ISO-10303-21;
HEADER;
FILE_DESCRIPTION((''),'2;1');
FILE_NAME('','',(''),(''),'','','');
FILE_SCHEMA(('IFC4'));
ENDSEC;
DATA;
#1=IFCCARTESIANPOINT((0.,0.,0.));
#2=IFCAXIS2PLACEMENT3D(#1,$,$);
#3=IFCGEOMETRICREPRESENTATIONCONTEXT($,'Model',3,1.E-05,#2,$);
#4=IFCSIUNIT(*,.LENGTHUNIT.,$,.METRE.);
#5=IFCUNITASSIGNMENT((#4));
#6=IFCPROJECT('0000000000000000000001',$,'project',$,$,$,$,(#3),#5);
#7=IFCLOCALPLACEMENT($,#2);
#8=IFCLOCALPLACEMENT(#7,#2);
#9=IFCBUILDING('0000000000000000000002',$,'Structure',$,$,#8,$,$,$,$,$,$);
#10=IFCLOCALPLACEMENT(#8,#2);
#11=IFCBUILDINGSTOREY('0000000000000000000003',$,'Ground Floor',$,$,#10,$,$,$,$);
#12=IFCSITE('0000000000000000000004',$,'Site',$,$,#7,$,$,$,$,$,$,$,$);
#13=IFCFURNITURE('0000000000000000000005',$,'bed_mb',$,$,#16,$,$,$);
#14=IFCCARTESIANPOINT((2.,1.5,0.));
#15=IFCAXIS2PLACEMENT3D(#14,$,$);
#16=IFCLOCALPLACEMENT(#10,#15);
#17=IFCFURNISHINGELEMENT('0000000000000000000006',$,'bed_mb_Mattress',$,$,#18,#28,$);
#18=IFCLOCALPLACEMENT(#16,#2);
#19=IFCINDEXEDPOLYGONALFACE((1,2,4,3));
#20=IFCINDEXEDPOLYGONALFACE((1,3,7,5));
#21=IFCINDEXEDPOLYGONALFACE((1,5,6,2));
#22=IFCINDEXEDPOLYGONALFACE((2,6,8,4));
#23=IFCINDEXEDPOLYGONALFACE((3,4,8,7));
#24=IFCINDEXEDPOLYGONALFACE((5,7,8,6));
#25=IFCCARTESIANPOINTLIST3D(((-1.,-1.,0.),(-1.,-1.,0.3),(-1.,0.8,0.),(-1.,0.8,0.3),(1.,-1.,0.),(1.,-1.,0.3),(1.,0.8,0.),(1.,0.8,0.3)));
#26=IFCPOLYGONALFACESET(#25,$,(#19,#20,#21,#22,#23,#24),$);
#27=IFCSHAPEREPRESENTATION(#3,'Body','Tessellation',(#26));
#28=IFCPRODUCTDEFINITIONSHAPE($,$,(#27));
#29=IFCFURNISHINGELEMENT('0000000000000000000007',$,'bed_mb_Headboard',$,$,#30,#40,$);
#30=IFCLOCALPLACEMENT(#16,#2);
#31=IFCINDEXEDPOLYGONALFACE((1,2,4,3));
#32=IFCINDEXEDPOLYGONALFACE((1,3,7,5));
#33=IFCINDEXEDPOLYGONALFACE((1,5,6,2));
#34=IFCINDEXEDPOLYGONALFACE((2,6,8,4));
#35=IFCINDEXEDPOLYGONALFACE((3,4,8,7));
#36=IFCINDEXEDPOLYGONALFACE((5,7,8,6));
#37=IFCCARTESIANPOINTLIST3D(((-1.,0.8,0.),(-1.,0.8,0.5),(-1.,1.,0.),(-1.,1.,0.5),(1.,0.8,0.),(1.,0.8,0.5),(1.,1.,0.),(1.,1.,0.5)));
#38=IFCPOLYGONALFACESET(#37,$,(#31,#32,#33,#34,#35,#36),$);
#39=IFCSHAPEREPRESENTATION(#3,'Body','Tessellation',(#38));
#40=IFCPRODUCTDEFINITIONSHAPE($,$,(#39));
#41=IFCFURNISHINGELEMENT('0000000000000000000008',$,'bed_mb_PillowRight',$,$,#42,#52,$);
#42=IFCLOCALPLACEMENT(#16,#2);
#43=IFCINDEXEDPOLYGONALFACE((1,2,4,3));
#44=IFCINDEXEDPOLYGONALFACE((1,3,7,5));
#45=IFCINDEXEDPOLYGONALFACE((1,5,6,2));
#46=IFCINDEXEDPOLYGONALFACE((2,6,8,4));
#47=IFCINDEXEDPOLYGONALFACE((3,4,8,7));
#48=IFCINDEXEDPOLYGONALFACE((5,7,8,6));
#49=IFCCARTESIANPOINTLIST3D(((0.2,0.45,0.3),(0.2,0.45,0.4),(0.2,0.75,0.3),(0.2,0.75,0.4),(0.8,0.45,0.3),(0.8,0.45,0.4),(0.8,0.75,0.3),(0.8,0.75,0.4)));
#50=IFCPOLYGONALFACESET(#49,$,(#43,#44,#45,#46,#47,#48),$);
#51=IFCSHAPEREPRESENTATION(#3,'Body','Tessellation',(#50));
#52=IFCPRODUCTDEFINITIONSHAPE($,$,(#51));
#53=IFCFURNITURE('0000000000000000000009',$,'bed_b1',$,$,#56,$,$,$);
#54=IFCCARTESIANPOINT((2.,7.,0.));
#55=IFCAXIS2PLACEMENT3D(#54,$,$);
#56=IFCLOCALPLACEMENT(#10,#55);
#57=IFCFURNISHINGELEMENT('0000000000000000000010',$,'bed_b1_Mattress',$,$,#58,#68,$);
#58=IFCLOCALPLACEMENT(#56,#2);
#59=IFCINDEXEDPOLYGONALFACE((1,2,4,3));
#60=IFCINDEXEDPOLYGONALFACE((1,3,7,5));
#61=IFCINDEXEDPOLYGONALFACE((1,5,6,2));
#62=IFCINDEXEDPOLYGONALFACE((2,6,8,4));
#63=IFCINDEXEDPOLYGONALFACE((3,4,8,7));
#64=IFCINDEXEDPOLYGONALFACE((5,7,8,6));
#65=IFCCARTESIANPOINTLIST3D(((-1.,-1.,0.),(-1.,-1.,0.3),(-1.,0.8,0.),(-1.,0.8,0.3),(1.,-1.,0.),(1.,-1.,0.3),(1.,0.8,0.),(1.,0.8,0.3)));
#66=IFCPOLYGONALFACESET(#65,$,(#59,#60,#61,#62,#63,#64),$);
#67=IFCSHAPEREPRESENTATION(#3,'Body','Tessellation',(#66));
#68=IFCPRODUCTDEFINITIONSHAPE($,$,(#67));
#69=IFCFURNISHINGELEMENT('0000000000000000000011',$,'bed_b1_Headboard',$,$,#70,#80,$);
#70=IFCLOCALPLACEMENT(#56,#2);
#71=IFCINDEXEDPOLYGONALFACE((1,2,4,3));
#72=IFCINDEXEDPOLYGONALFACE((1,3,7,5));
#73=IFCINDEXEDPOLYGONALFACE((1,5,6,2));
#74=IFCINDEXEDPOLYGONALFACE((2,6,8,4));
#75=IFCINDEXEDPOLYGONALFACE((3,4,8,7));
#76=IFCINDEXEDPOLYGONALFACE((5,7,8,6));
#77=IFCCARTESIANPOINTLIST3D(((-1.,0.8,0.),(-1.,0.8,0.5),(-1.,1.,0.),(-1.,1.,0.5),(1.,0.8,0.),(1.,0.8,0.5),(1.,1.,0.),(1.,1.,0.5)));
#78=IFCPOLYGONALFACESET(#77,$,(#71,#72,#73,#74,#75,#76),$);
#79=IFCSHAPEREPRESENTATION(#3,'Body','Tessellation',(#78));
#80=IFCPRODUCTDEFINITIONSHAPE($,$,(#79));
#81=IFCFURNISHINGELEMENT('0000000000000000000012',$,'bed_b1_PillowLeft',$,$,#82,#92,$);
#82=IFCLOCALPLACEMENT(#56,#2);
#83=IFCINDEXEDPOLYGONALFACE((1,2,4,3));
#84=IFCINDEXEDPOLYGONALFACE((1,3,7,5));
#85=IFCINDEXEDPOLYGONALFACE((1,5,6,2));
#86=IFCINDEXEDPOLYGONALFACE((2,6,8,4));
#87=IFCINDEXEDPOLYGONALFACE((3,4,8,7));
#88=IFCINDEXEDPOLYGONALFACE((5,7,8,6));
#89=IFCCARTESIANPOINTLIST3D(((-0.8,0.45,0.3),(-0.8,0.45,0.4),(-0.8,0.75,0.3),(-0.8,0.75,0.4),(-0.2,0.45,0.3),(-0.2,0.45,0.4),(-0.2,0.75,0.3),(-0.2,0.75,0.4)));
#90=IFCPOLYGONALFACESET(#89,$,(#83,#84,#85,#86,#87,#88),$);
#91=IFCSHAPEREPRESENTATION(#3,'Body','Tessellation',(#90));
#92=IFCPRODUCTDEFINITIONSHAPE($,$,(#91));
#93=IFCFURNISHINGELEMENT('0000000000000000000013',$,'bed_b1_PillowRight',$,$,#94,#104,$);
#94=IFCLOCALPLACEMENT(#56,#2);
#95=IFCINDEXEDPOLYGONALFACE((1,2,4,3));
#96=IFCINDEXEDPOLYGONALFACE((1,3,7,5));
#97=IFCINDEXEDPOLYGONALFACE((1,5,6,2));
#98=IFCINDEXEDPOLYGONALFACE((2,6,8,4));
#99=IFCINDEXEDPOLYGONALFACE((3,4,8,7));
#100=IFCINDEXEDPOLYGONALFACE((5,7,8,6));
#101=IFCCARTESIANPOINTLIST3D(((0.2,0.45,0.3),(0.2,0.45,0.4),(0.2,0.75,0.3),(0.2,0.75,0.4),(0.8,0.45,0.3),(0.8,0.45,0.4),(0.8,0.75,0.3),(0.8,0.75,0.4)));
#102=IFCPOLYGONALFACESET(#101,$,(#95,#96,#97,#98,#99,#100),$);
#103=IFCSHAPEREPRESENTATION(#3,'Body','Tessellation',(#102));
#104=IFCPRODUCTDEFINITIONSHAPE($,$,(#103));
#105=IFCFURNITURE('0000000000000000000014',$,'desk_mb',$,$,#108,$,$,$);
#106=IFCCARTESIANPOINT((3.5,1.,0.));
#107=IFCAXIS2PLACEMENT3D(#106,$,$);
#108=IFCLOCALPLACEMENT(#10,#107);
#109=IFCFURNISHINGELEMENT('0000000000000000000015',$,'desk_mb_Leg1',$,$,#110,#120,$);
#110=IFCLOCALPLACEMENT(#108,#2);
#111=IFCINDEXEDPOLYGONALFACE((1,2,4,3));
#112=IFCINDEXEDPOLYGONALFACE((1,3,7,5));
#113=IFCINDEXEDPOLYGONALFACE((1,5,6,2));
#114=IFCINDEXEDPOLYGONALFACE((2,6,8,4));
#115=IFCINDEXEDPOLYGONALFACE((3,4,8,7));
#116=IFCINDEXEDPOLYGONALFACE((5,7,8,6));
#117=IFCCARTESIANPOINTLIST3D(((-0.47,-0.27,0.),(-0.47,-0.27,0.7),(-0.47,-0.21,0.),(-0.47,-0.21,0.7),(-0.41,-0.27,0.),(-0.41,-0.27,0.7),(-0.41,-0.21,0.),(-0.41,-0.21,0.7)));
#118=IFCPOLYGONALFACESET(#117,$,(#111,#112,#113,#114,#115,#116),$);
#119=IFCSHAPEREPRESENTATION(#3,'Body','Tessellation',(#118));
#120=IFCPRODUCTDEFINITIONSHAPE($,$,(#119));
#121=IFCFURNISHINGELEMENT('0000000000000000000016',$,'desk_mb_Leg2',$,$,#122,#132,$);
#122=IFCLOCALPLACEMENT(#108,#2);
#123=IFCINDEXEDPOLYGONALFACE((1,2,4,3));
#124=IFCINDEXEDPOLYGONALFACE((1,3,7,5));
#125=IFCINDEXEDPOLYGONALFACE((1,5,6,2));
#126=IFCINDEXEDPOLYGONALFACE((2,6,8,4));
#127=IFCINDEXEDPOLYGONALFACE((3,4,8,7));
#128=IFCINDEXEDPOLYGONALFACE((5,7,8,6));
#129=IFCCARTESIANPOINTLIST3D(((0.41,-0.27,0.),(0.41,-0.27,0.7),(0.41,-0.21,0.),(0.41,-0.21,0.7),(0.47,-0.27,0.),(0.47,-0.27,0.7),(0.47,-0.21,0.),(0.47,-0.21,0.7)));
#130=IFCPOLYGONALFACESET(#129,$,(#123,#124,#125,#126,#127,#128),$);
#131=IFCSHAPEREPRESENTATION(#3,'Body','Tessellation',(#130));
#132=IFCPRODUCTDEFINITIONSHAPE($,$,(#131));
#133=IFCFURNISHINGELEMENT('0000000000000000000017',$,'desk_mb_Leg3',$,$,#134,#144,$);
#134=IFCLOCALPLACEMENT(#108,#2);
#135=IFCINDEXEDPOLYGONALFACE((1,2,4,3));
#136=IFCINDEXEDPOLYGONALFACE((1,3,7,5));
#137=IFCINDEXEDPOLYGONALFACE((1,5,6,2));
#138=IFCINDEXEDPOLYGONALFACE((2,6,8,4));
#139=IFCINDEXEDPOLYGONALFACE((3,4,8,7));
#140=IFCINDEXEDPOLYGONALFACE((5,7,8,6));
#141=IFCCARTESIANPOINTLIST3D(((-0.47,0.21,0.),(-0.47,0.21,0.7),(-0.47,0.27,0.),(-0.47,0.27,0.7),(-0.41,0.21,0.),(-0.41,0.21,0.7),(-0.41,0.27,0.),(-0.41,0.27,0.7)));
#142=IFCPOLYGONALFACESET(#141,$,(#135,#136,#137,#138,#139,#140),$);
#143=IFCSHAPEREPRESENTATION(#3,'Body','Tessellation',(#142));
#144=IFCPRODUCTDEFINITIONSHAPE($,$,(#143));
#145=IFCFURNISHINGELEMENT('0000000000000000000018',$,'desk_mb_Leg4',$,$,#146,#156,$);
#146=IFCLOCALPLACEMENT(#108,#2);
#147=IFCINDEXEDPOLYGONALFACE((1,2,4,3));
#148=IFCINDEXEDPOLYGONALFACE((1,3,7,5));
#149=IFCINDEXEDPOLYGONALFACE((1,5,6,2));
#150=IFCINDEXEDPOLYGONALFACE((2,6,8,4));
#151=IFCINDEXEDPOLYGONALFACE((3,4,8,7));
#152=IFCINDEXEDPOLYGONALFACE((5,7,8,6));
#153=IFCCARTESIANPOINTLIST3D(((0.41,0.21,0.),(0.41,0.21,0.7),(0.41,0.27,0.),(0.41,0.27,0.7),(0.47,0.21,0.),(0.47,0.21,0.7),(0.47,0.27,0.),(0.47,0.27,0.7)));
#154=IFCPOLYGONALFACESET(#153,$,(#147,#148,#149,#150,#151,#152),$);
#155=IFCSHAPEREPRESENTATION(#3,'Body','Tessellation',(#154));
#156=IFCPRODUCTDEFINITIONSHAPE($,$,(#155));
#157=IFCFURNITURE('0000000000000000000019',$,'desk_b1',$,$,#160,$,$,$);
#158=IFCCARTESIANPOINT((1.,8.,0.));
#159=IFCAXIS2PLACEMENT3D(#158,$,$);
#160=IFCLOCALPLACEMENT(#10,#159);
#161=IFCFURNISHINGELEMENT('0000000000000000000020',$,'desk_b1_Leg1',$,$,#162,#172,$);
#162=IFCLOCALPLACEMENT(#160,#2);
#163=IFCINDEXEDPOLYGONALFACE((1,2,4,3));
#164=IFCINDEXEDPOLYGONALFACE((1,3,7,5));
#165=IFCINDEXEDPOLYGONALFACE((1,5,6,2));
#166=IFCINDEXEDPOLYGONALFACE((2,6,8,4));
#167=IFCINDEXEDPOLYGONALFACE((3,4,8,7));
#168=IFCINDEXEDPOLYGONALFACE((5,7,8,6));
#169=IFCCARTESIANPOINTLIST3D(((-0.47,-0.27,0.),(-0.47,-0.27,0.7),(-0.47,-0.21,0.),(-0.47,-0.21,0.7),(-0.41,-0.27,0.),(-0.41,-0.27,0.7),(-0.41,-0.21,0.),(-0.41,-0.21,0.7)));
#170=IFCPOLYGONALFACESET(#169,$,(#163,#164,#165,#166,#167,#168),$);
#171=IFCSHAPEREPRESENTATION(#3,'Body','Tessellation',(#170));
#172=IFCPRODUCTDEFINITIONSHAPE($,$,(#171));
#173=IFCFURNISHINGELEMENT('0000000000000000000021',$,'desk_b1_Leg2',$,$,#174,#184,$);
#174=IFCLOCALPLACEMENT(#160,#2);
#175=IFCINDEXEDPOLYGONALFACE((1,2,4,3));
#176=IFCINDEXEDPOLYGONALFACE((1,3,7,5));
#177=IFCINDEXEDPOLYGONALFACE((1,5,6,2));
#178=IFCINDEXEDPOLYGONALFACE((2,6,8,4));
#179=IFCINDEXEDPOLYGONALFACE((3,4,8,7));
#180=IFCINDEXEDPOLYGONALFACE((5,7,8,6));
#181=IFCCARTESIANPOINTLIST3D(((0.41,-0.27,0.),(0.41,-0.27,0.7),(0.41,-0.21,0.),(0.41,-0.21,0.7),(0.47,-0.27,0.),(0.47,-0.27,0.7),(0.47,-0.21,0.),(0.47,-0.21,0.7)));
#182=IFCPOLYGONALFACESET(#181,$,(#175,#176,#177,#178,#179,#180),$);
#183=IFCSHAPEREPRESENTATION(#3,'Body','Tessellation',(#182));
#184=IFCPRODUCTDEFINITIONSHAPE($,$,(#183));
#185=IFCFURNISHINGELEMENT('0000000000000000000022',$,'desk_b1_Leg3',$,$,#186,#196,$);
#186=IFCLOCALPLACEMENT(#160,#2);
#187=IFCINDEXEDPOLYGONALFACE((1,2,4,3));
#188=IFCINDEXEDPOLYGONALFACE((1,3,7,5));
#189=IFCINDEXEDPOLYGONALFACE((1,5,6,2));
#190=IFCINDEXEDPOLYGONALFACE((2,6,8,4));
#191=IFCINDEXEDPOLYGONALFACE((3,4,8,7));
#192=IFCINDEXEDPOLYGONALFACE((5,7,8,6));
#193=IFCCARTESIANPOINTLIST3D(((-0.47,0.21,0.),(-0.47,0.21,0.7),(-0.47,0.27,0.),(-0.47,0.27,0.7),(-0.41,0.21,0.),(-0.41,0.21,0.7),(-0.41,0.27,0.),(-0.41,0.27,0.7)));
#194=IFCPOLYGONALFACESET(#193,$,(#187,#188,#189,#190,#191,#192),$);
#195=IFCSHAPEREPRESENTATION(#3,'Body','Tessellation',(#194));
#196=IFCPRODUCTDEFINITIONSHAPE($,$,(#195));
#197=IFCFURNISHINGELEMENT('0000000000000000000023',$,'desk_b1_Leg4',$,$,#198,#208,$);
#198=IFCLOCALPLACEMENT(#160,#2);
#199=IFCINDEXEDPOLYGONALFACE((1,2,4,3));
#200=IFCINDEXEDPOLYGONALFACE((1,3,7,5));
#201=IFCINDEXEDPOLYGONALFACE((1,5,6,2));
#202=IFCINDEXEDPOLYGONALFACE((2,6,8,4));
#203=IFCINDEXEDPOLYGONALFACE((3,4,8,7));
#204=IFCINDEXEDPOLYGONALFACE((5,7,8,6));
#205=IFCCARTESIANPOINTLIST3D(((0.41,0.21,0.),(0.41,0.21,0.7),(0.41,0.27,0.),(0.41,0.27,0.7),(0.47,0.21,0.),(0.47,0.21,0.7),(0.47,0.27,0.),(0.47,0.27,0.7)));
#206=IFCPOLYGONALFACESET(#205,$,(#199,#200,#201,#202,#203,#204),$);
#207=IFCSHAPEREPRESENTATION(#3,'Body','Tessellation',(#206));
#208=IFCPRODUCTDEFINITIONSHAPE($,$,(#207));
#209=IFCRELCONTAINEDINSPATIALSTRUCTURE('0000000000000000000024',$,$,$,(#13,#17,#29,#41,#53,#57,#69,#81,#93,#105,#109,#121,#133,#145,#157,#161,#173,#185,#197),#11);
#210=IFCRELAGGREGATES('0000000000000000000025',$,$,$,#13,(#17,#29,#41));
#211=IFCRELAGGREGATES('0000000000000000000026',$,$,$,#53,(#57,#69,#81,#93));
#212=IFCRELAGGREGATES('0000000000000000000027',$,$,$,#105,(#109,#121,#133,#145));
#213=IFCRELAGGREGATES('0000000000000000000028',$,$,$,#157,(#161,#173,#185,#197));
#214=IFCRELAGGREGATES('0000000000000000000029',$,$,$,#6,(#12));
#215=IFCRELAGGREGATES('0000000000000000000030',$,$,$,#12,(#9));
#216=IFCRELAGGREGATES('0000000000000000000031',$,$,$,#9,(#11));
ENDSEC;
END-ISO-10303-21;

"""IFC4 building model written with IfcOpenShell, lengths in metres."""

from ifc_helpers import new_model, si_unit, frame, origin, origin_2d, place, context, project, spatial, rectangle, extrude, element, aggregate, save


model = new_model("IFC4")

# Units and contexts
model_context = context("Model", 3, precision=1e-05, world=origin())
ifc_project = project(units=[si_unit("LENGTHUNIT", "METRE")], contexts=[model_context])

# Site, building, storey
site_placement = place(None, origin())
site = spatial("IfcSite", under=ifc_project, at=site_placement, Name="Site")
building_placement = place(site_placement, origin())
building = spatial("IfcBuilding", under=site, at=building_placement, Name="Structure")
storey_placement = place(building_placement, origin())
storey = spatial("IfcBuildingStorey", under=building, at=storey_placement, Name="Ground Floor")

# Furniture, furnishing elements
furniture_1_placement = place(storey_placement, frame((2.0, 1.5, 0.0)))
furniture_1 = element("IfcFurniture", 1, at=furniture_1_placement, inside=storey, Name="bed_mb")
furnishing_1_placement = place(furniture_1_placement, origin())
furnishing_1 = element("IfcFurnishingElement", 2, at=furnishing_1_placement, inside=storey, Name="bed_mb_Mattress", context=model_context, shape_type="SweptSolid", body=[
    extrude(rectangle(XDim=2.0, YDim=1.8, at=origin_2d()), frame((0.0, -0.1, 0.0)), (0.0, 0.0, 1.0), 0.3),
])
furnishing_2_placement = place(furniture_1_placement, origin())
furnishing_2 = element("IfcFurnishingElement", 3, at=furnishing_2_placement, inside=storey, Name="bed_mb_Headboard", context=model_context, shape_type="SweptSolid", body=[
    extrude(rectangle(XDim=2.0, YDim=0.2, at=origin_2d()), frame((0.0, 0.9, 0.0)), (0.0, 0.0, 1.0), 0.5),
])
furnishing_3_placement = place(furniture_1_placement, origin())
furnishing_3 = element("IfcFurnishingElement", 4, at=furnishing_3_placement, inside=storey, Name="bed_mb_PillowRight", context=model_context, shape_type="SweptSolid", body=[
    extrude(rectangle(XDim=0.6, YDim=0.3, at=origin_2d()), frame((0.5, 0.6, 0.3)), (0.0, 0.0, 1.0), 0.1),
])
aggregate(furniture_1, [furnishing_1, furnishing_2, furnishing_3])
furniture_2_placement = place(storey_placement, frame((2.0, 7.0, 0.0)))
furniture_2 = element("IfcFurniture", 5, at=furniture_2_placement, inside=storey, Name="bed_b1")
furnishing_4_placement = place(furniture_2_placement, origin())
furnishing_4 = element("IfcFurnishingElement", 6, at=furnishing_4_placement, inside=storey, Name="bed_b1_Mattress", context=model_context, shape_type="SweptSolid", body=[
    extrude(rectangle(XDim=2.0, YDim=1.8, at=origin_2d()), frame((0.0, -0.1, 0.0)), (0.0, 0.0, 1.0), 0.3),
])
furnishing_5_placement = place(furniture_2_placement, origin())
furnishing_5 = element("IfcFurnishingElement", 7, at=furnishing_5_placement, inside=storey, Name="bed_b1_Headboard", context=model_context, shape_type="SweptSolid", body=[
    extrude(rectangle(XDim=2.0, YDim=0.2, at=origin_2d()), frame((0.0, 0.9, 0.0)), (0.0, 0.0, 1.0), 0.5),
])
furnishing_6_placement = place(furniture_2_placement, origin())
furnishing_6 = element("IfcFurnishingElement", 8, at=furnishing_6_placement, inside=storey, Name="bed_b1_PillowLeft", context=model_context, shape_type="SweptSolid", body=[
    extrude(rectangle(XDim=0.6, YDim=0.3, at=origin_2d()), frame((-0.5, 0.6, 0.3)), (0.0, 0.0, 1.0), 0.1),
])
furnishing_7_placement = place(furniture_2_placement, origin())
furnishing_7 = element("IfcFurnishingElement", 9, at=furnishing_7_placement, inside=storey, Name="bed_b1_PillowRight", context=model_context, shape_type="SweptSolid", body=[
    extrude(rectangle(XDim=0.6, YDim=0.3, at=origin_2d()), frame((0.5, 0.6, 0.3)), (0.0, 0.0, 1.0), 0.1),
])
aggregate(furniture_2, [furnishing_4, furnishing_5, furnishing_6, furnishing_7])

# Furniture, furnishing elements
furniture_3_placement = place(storey_placement, frame((3.5, 1.0, 0.0)))
furniture_3 = element("IfcFurniture", 10, at=furniture_3_placement, inside=storey, Name="desk_mb")
furnishing_8_placement = place(furniture_3_placement, origin())
furnishing_8 = element("IfcFurnishingElement", 11, at=furnishing_8_placement, inside=storey, Name="desk_mb_Leg1", context=model_context, shape_type="SweptSolid", body=[
    extrude(rectangle(XDim=0.06, YDim=0.06, at=origin_2d()), frame((-0.44, -0.24, 0.0)), (0.0, 0.0, 1.0), 0.7),
])
furnishing_9_placement = place(furniture_3_placement, origin())
furnishing_9 = element("IfcFurnishingElement", 12, at=furnishing_9_placement, inside=storey, Name="desk_mb_Leg2", context=model_context, shape_type="SweptSolid", body=[
    extrude(rectangle(XDim=0.06, YDim=0.06, at=origin_2d()), frame((0.44, -0.24, 0.0)), (0.0, 0.0, 1.0), 0.7),
])
furnishing_10_placement = place(furniture_3_placement, origin())
furnishing_10 = element("IfcFurnishingElement", 13, at=furnishing_10_placement, inside=storey, Name="desk_mb_Leg3", context=model_context, shape_type="SweptSolid", body=[
    extrude(rectangle(XDim=0.06, YDim=0.06, at=origin_2d()), frame((-0.44, 0.24, 0.0)), (0.0, 0.0, 1.0), 0.7),
])
furnishing_11_placement = place(furniture_3_placement, origin())
furnishing_11 = element("IfcFurnishingElement", 14, at=furnishing_11_placement, inside=storey, Name="desk_mb_Leg4", context=model_context, shape_type="SweptSolid", body=[
    extrude(rectangle(XDim=0.06, YDim=0.06, at=origin_2d()), frame((0.44, 0.24, 0.0)), (0.0, 0.0, 1.0), 0.7),
])
aggregate(furniture_3, [furnishing_8, furnishing_9, furnishing_10, furnishing_11])
furniture_4_placement = place(storey_placement, frame((1.0, 8.0, 0.0)))
furniture_4 = element("IfcFurniture", 15, at=furniture_4_placement, inside=storey, Name="desk_b1")
furnishing_12_placement = place(furniture_4_placement, origin())
furnishing_12 = element("IfcFurnishingElement", 16, at=furnishing_12_placement, inside=storey, Name="desk_b1_Leg1", context=model_context, shape_type="SweptSolid", body=[
    extrude(rectangle(XDim=0.06, YDim=0.06, at=origin_2d()), frame((-0.44, -0.24, 0.0)), (0.0, 0.0, 1.0), 0.7),
])
furnishing_13_placement = place(furniture_4_placement, origin())
furnishing_13 = element("IfcFurnishingElement", 17, at=furnishing_13_placement, inside=storey, Name="desk_b1_Leg2", context=model_context, shape_type="SweptSolid", body=[
    extrude(rectangle(XDim=0.06, YDim=0.06, at=origin_2d()), frame((0.44, -0.24, 0.0)), (0.0, 0.0, 1.0), 0.7),
])
furnishing_14_placement = place(furniture_4_placement, origin())
furnishing_14 = element("IfcFurnishingElement", 18, at=furnishing_14_placement, inside=storey, Name="desk_b1_Leg3", context=model_context, shape_type="SweptSolid", body=[
    extrude(rectangle(XDim=0.06, YDim=0.06, at=origin_2d()), frame((-0.44, 0.24, 0.0)), (0.0, 0.0, 1.0), 0.7),
])
furnishing_15_placement = place(furniture_4_placement, origin())
furnishing_15 = element("IfcFurnishingElement", 19, at=furnishing_15_placement, inside=storey, Name="desk_b1_Leg4", context=model_context, shape_type="SweptSolid", body=[
    extrude(rectangle(XDim=0.06, YDim=0.06, at=origin_2d()), frame((0.44, 0.24, 0.0)), (0.0, 0.0, 1.0), 0.7),
])
aggregate(furniture_4, [furnishing_12, furnishing_13, furnishing_14, furnishing_15])

save(model, "model.ifc")
